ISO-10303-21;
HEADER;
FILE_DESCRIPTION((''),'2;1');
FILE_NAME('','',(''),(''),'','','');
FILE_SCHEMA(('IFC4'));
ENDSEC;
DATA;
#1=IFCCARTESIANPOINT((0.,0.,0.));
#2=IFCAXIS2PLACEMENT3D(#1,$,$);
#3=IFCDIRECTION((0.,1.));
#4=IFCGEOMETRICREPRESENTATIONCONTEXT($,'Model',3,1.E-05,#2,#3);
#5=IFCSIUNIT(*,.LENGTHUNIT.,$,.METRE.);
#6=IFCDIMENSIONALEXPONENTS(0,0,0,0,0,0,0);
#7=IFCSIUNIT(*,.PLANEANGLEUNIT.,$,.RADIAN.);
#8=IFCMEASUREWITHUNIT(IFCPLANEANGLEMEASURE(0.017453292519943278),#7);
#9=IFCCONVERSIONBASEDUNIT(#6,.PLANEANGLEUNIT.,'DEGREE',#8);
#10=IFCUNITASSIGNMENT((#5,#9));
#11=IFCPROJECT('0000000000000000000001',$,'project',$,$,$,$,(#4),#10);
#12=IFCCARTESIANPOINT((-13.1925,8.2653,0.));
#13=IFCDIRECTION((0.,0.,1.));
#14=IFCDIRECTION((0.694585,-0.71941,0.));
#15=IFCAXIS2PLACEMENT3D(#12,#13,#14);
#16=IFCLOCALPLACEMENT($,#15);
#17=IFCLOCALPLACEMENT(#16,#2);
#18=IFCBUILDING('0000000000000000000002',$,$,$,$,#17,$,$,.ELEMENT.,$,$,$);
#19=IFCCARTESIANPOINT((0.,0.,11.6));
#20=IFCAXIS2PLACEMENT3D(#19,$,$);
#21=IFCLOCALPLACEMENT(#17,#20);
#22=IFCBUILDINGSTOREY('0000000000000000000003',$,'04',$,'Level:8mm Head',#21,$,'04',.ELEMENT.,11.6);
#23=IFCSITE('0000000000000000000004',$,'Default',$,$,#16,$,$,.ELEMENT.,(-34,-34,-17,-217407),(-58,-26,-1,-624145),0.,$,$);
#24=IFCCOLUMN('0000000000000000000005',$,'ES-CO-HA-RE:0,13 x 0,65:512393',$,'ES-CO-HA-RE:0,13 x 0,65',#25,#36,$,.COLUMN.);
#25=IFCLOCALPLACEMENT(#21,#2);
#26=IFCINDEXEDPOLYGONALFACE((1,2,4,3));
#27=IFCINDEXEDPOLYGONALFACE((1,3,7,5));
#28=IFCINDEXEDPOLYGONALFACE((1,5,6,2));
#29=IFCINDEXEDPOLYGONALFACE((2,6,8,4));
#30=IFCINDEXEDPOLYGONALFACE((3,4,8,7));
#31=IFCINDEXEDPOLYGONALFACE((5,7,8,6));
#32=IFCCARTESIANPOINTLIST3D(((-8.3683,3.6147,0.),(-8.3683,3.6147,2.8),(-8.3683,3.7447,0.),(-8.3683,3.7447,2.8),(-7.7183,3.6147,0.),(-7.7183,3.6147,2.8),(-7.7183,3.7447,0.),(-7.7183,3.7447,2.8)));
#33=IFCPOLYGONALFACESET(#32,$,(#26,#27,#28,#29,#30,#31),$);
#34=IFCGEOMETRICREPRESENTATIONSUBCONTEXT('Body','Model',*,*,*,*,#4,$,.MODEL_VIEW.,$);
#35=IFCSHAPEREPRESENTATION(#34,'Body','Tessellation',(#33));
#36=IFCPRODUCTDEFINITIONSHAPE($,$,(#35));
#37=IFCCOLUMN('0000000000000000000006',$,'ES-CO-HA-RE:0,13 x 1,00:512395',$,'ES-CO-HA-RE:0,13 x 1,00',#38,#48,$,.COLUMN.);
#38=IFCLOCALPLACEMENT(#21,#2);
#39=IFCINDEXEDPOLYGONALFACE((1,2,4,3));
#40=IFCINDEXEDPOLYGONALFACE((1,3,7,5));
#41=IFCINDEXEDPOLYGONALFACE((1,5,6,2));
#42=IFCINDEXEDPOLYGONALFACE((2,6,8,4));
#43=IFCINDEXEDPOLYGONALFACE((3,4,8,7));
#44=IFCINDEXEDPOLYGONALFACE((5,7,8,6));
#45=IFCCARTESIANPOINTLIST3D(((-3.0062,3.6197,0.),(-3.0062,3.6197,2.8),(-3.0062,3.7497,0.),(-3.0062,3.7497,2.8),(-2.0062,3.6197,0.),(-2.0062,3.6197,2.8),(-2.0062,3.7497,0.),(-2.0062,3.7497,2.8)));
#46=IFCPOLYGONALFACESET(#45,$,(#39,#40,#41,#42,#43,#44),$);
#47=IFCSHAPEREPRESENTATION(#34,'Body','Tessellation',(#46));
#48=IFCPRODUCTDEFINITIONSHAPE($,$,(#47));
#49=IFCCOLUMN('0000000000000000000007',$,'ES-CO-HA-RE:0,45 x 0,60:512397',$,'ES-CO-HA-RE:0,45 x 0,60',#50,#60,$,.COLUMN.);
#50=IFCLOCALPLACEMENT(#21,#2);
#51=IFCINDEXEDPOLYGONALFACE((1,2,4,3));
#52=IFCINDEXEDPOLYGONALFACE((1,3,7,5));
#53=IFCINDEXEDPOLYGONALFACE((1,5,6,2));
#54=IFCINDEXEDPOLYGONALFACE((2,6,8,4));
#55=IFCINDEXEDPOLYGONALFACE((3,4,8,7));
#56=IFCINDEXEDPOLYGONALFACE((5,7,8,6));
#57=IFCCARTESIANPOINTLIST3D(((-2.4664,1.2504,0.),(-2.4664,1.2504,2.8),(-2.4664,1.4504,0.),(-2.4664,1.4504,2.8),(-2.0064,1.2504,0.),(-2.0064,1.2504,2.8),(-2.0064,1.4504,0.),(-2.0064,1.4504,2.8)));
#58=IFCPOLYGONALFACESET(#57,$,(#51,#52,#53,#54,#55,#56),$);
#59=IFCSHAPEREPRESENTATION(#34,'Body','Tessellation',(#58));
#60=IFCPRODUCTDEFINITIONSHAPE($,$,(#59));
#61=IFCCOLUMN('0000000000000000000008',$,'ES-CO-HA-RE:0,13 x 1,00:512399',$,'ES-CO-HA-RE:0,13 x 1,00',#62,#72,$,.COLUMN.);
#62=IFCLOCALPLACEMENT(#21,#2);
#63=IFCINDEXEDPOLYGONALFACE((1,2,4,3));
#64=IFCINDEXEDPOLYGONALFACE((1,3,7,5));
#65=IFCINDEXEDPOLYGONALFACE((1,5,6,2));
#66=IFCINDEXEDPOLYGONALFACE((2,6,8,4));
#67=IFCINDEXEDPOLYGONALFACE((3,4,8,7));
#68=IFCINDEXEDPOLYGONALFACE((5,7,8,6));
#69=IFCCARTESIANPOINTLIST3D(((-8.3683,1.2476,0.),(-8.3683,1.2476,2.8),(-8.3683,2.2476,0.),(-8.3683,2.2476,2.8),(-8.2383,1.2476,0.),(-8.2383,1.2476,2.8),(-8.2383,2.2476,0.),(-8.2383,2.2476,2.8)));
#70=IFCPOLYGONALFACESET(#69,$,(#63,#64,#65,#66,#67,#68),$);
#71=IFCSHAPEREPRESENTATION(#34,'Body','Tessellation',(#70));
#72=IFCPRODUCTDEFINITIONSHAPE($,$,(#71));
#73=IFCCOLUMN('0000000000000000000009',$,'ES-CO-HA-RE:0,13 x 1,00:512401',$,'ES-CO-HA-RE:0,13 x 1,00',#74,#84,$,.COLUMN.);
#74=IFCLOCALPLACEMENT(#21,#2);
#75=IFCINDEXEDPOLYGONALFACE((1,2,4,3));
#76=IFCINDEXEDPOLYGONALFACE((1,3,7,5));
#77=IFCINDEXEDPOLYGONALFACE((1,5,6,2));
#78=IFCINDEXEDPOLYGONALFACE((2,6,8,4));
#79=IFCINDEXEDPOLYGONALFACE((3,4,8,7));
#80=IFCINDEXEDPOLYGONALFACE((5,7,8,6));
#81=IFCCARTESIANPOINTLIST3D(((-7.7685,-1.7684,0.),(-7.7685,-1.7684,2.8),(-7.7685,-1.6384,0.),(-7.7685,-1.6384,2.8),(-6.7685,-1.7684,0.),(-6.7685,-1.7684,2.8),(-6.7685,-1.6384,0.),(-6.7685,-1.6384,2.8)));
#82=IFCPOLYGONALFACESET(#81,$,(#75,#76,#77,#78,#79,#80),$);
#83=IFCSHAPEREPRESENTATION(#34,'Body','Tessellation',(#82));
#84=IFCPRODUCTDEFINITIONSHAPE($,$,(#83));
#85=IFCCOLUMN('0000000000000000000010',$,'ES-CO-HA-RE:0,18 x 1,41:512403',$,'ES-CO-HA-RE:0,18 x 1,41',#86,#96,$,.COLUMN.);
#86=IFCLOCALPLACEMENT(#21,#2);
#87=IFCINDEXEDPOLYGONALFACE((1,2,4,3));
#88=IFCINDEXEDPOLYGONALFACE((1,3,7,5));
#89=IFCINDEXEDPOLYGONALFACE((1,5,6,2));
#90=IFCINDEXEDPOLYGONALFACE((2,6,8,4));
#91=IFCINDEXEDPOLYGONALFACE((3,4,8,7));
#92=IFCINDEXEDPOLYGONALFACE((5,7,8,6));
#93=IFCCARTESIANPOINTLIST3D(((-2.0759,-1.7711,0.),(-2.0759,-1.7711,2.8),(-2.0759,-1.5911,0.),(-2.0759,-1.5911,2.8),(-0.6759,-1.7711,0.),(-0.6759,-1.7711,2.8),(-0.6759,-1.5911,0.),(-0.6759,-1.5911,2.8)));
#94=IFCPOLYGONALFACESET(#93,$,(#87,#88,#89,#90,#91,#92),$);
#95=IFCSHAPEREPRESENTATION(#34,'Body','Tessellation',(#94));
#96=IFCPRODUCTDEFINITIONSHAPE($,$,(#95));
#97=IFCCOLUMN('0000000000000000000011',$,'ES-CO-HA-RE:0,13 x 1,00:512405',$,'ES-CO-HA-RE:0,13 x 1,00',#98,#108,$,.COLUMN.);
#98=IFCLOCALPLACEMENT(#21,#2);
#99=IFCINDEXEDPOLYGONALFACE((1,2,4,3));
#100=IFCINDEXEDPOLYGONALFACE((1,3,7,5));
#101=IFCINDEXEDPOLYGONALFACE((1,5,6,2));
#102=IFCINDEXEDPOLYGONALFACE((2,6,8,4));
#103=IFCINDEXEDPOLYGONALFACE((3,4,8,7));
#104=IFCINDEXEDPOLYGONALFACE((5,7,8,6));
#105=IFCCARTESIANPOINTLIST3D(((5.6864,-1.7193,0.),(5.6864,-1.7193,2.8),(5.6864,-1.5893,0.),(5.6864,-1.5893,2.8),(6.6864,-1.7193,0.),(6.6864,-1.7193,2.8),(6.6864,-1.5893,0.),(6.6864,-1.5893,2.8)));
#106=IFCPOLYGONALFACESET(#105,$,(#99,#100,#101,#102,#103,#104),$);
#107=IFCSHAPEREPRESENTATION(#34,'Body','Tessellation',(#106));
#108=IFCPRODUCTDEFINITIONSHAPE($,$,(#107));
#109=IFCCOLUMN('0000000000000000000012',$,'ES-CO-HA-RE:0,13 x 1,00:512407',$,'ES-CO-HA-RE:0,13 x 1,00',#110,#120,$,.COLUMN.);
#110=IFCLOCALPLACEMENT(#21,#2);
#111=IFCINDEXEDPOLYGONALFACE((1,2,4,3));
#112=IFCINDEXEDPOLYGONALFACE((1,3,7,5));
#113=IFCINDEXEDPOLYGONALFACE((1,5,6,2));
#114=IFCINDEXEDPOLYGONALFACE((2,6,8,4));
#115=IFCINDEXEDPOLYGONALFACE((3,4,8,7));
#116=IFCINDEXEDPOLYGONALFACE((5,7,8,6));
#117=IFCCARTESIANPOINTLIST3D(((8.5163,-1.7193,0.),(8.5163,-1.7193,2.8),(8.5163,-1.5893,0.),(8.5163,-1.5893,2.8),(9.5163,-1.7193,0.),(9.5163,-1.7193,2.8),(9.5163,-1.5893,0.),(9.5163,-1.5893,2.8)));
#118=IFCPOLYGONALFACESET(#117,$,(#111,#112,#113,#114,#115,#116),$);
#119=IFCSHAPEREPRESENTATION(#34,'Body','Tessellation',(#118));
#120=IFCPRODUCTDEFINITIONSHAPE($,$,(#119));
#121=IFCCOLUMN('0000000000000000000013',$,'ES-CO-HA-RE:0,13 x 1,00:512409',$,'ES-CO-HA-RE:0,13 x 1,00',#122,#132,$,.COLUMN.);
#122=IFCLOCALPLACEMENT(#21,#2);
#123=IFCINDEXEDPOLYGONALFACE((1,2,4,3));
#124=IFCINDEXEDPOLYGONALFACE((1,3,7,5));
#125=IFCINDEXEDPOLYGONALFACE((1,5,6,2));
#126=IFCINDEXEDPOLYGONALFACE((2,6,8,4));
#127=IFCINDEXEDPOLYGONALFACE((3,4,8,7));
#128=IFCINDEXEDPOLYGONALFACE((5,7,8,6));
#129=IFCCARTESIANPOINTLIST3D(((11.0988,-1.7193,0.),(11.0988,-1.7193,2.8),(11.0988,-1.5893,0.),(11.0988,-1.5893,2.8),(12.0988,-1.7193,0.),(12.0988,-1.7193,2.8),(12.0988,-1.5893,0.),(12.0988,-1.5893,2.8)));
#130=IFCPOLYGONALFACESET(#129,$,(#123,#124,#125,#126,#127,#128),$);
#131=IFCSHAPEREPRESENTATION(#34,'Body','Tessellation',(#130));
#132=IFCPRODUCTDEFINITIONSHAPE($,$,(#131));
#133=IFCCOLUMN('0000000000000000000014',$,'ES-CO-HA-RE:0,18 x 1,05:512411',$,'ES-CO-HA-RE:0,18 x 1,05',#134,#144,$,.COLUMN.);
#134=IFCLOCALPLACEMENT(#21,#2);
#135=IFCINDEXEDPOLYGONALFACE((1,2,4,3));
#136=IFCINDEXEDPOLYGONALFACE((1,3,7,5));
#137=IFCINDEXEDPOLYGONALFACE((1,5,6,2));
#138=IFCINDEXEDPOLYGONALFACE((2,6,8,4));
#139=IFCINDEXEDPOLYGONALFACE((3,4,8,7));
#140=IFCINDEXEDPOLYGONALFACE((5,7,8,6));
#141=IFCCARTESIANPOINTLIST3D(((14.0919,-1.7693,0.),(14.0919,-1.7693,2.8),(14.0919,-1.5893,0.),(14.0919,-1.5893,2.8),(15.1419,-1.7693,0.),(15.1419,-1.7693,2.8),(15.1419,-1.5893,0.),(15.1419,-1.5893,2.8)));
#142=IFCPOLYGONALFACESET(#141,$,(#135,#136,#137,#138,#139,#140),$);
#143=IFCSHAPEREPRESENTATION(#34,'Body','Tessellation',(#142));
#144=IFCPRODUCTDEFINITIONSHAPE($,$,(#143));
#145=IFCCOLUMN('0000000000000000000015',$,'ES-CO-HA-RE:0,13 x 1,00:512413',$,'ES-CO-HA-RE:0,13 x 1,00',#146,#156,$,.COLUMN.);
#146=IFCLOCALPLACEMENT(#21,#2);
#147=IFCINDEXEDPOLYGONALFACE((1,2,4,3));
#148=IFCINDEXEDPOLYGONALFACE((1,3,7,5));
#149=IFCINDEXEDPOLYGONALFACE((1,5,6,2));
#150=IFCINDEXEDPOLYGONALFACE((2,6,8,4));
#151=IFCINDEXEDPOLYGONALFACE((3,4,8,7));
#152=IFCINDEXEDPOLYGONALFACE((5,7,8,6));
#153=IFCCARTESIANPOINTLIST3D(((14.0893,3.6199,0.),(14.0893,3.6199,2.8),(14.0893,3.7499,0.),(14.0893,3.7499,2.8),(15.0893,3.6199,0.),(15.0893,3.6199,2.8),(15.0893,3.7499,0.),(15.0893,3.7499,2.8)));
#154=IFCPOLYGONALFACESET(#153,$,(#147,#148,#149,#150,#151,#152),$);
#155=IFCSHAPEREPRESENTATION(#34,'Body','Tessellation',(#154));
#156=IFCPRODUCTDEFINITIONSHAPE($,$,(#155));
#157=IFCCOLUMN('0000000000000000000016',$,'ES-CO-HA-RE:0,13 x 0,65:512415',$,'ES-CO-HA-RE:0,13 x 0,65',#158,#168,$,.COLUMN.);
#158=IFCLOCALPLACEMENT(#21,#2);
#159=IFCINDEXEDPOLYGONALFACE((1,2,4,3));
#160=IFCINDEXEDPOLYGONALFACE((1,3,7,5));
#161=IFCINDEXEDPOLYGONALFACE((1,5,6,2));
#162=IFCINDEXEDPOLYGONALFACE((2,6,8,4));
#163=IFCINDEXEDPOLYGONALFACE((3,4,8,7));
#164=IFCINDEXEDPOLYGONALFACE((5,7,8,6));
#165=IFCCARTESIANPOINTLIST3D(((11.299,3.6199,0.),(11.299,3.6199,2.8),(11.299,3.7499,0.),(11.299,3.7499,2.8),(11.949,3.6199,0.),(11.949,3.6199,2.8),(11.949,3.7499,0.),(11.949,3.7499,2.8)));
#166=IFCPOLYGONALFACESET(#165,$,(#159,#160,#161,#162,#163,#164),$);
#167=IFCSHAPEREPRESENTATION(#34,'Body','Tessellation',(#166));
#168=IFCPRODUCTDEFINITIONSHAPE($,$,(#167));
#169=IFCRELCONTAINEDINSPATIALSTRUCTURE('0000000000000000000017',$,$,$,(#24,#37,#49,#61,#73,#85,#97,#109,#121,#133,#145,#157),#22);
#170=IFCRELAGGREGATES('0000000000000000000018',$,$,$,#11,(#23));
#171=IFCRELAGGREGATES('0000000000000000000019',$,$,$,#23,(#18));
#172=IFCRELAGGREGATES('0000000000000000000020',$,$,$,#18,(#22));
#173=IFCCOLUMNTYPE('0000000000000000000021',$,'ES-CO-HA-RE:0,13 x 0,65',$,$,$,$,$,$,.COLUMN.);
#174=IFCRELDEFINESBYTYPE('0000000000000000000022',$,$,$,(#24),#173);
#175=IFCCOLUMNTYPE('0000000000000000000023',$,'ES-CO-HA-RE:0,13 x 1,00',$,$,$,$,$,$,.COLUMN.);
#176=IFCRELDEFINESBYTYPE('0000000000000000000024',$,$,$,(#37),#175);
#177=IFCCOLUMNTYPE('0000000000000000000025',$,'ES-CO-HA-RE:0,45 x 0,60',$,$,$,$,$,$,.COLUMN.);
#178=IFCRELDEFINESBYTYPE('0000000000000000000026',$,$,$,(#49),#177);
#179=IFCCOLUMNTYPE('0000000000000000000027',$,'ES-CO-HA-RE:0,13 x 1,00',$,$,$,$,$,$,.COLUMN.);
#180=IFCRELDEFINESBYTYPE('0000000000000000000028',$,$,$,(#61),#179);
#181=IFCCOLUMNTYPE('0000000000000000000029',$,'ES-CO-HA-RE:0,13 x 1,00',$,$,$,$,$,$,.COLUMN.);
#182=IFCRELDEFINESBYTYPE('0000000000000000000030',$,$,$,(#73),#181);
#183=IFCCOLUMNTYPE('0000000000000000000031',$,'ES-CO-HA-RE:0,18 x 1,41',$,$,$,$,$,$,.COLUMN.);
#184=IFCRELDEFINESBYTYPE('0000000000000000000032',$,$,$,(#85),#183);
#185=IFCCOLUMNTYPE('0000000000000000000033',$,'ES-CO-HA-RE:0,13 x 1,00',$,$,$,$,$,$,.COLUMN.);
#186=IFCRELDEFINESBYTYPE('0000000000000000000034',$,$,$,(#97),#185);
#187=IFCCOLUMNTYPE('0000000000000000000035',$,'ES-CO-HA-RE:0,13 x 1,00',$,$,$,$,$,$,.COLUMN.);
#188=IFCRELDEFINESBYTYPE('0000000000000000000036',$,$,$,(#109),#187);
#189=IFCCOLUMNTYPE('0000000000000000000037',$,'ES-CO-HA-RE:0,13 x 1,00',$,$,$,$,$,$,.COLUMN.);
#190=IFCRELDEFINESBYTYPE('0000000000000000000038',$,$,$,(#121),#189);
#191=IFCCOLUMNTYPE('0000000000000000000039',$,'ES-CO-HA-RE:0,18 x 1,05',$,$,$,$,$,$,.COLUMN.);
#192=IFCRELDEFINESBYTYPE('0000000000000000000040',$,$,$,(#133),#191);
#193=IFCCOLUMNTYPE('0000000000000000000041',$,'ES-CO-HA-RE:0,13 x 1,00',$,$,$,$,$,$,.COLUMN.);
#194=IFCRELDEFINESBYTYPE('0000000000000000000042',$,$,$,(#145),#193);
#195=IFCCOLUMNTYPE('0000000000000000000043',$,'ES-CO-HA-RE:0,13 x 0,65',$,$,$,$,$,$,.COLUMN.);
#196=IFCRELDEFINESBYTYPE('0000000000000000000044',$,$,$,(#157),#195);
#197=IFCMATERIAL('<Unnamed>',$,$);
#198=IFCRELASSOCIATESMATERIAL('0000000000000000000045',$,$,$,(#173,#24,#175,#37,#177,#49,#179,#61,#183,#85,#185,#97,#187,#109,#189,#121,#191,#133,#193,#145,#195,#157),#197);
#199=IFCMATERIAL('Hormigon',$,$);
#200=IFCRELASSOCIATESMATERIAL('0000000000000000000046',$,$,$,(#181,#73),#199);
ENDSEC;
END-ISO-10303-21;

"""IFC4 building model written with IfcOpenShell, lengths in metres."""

from ifc_helpers import new_model, entity, si_unit, converted_unit, direction, frame, origin, place, context, subcontext, project, spatial, indexed_curve, outline, extrude, source, transform, mapped, material, type_object, type_shapes, element, save


model = new_model("IFC4")

# Units and contexts
model_context = context("Model", 3, precision=1e-05, world=origin(), true_north=direction((0.0, 1.0)))
body_context = subcontext(model_context, "Body", "Model", "MODEL_VIEW")
ifc_project = project(units=[si_unit("LENGTHUNIT", "METRE"), converted_unit("PLANEANGLEUNIT", "DEGREE", entity("IfcPlaneAngleMeasure", 0.017453292519943278), si_unit("PLANEANGLEUNIT", "RADIAN"), dimensions=[0, 0, 0, 0, 0, 0, 0])], contexts=[model_context])

# Site, building, storey
site_placement = place(None, frame((-13.1925, 8.2653, 0.0), z_axis=(0.0, 0.0, 1.0), x_axis=(0.694585, -0.71941, 0.0)))
site = spatial("IfcSite", under=ifc_project, at=site_placement, Name="Default", CompositionType="ELEMENT", RefLatitude=(-34, -34, -17, -217407), RefLongitude=(-58, -26, -1, -624145), RefElevation=0.0)
building_placement = place(site_placement, origin())
building = spatial("IfcBuilding", under=site, at=building_placement, CompositionType="ELEMENT")
storey_placement = place(building_placement, frame((0.0, 0.0, 11.6)))
storey = spatial("IfcBuildingStorey", under=building, at=storey_placement, Name="04", ObjectType="Level:8mm Head", LongName="04", CompositionType="ELEMENT", Elevation=11.6)

# Columns
ifc_material_1 = material(Name="<Unnamed>")
column_type_1 = type_object("IfcColumnType", Name="ES-CO-HA-RE:0,13 x 0,65", PredefinedType="COLUMN", material=ifc_material_1)
shared_shape_1 = source(origin(), body_context, "Body", "SweptSolid", [
    extrude(outline(indexed_curve([(-0.325, -0.065), (0.325, -0.065), (0.325, 0.065), (-0.325, 0.065), (-0.325, -0.065)], self_intersect=False)), frame((-8.0433, 3.6797, 11.6), z_axis=(0.0, 0.0, 1.0), x_axis=(-1.0, 0.0, 0.0)), (0.0, 0.0, 1.0), 2.8),
])
type_shapes(column_type_1, [shared_shape_1])
column_1_placement = place(storey_placement, frame((0.0, 0.0, -11.6)))
element("IfcColumn", 1, at=column_1_placement, inside=storey, type_object=column_type_1, material=ifc_material_1, Name="ES-CO-HA-RE:0,13 x 0,65:512393", ObjectType="ES-CO-HA-RE:0,13 x 0,65", PredefinedType="COLUMN", context=body_context, shape_type="MappedRepresentation", body=[
    mapped(shared_shape_1, transform((0.0, 0.0, 0.0), scale=1.0)),
])
column_type_2 = type_object("IfcColumnType", Name="ES-CO-HA-RE:0,13 x 1,00", PredefinedType="COLUMN", material=ifc_material_1)
shared_shape_2 = source(origin(), body_context, "Body", "SweptSolid", [
    extrude(outline(indexed_curve([(-0.5, -0.065), (0.5, -0.065), (0.5, 0.065), (-0.5, 0.065), (-0.5, -0.065)], self_intersect=False)), frame((-2.5062, 3.6847, 11.6), z_axis=(0.0, 0.0, 1.0), x_axis=(-1.0, 0.0, 0.0)), (0.0, 0.0, 1.0), 2.8),
])
type_shapes(column_type_2, [shared_shape_2])
column_2_placement = place(storey_placement, frame((0.0, 0.0, -11.6)))
element("IfcColumn", 2, at=column_2_placement, inside=storey, type_object=column_type_2, material=ifc_material_1, Name="ES-CO-HA-RE:0,13 x 1,00:512395", ObjectType="ES-CO-HA-RE:0,13 x 1,00", PredefinedType="COLUMN", context=body_context, shape_type="MappedRepresentation", body=[
    mapped(shared_shape_2, transform((0.0, 0.0, 0.0), scale=1.0)),
])
column_type_3 = type_object("IfcColumnType", Name="ES-CO-HA-RE:0,45 x 0,60", PredefinedType="COLUMN", material=ifc_material_1)
shared_shape_3 = source(origin(), body_context, "Body", "SweptSolid", [
    extrude(outline(indexed_curve([(-0.23, -0.1), (0.23, -0.1), (0.23, 0.1), (-0.23, 0.1), (-0.23, -0.1)], self_intersect=False)), frame((-2.2364, 1.3504, 11.6), z_axis=(0.0, 0.0, 1.0), x_axis=(-1.0, 0.0, 0.0)), (0.0, 0.0, 1.0), 2.8),
])
type_shapes(column_type_3, [shared_shape_3])
column_3_placement = place(storey_placement, frame((0.0, 0.0, -11.6)))
element("IfcColumn", 3, at=column_3_placement, inside=storey, type_object=column_type_3, material=ifc_material_1, Name="ES-CO-HA-RE:0,45 x 0,60:512397", ObjectType="ES-CO-HA-RE:0,45 x 0,60", PredefinedType="COLUMN", context=body_context, shape_type="MappedRepresentation", body=[
    mapped(shared_shape_3, transform((0.0, 0.0, 0.0), scale=1.0)),
])
column_type_4 = type_object("IfcColumnType", Name="ES-CO-HA-RE:0,13 x 1,00", PredefinedType="COLUMN", material=ifc_material_1)
shared_shape_4 = source(origin(), body_context, "Body", "SweptSolid", [
    extrude(outline(indexed_curve([(-0.5, -0.065), (0.5, -0.065), (0.5, 0.065), (-0.5, 0.065), (-0.5, -0.065)], self_intersect=False)), frame((-8.3033, 1.7476, 11.6), z_axis=(0.0, 0.0, 1.0), x_axis=(0.0, -1.0, 0.0)), (0.0, 0.0, 1.0), 2.8),
])
type_shapes(column_type_4, [shared_shape_4])
column_4_placement = place(storey_placement, frame((0.0, 0.0, -11.6)))
element("IfcColumn", 4, at=column_4_placement, inside=storey, type_object=column_type_4, material=ifc_material_1, Name="ES-CO-HA-RE:0,13 x 1,00:512399", ObjectType="ES-CO-HA-RE:0,13 x 1,00", PredefinedType="COLUMN", context=body_context, shape_type="MappedRepresentation", body=[
    mapped(shared_shape_4, transform((0.0, 0.0, 0.0), scale=1.0)),
])
ifc_material_2 = material(Name="Hormigon")
column_type_5 = type_object("IfcColumnType", Name="ES-CO-HA-RE:0,13 x 1,00", PredefinedType="COLUMN", material=ifc_material_2)
shared_shape_5 = source(origin(), body_context, "Body", "SweptSolid", [
    extrude(outline(indexed_curve([(-0.5, -0.065), (0.5, -0.065), (0.5, 0.065), (-0.5, 0.065), (-0.5, -0.065)], self_intersect=False)), frame((-7.2685, -1.7034, 11.6), z_axis=(0.0, 0.0, 1.0), x_axis=(-1.0, 0.0, 0.0)), (0.0, 0.0, 1.0), 2.8),
])
type_shapes(column_type_5, [shared_shape_5])
column_5_placement = place(storey_placement, frame((0.0, 0.0, -11.6)))
element("IfcColumn", 5, at=column_5_placement, inside=storey, type_object=column_type_5, material=ifc_material_2, Name="ES-CO-HA-RE:0,13 x 1,00:512401", ObjectType="ES-CO-HA-RE:0,13 x 1,00", PredefinedType="COLUMN", context=body_context, shape_type="MappedRepresentation", body=[
    mapped(shared_shape_5, transform((0.0, 0.0, 0.0), scale=1.0)),
])
column_type_6 = type_object("IfcColumnType", Name="ES-CO-HA-RE:0,18 x 1,41", PredefinedType="COLUMN", material=ifc_material_1)
shared_shape_6 = source(origin(), body_context, "Body", "SweptSolid", [
    extrude(outline(indexed_curve([(-0.7, -0.09), (0.7, -0.09), (0.7, 0.09), (-0.7, 0.09), (-0.7, -0.09)], self_intersect=False)), frame((-1.3759, -1.6811, 11.6), z_axis=(0.0, 0.0, 1.0), x_axis=(-1.0, 0.0, 0.0)), (0.0, 0.0, 1.0), 2.8),
])
type_shapes(column_type_6, [shared_shape_6])
column_6_placement = place(storey_placement, frame((0.0, 0.0, -11.6)))
element("IfcColumn", 6, at=column_6_placement, inside=storey, type_object=column_type_6, material=ifc_material_1, Name="ES-CO-HA-RE:0,18 x 1,41:512403", ObjectType="ES-CO-HA-RE:0,18 x 1,41", PredefinedType="COLUMN", context=body_context, shape_type="MappedRepresentation", body=[
    mapped(shared_shape_6, transform((0.0, 0.0, 0.0), scale=1.0)),
])
column_type_7 = type_object("IfcColumnType", Name="ES-CO-HA-RE:0,13 x 1,00", PredefinedType="COLUMN", material=ifc_material_1)
shared_shape_7 = source(origin(), body_context, "Body", "SweptSolid", [
    extrude(outline(indexed_curve([(-0.5, -0.065), (0.5, -0.065), (0.5, 0.065), (-0.5, 0.065), (-0.5, -0.065)], self_intersect=False)), frame((6.1864, -1.6543, 11.6), z_axis=(0.0, 0.0, 1.0), x_axis=(-1.0, 0.0, 0.0)), (0.0, 0.0, 1.0), 2.8),
])
type_shapes(column_type_7, [shared_shape_7])
column_7_placement = place(storey_placement, frame((0.0, 0.0, -11.6)))
element("IfcColumn", 7, at=column_7_placement, inside=storey, type_object=column_type_7, material=ifc_material_1, Name="ES-CO-HA-RE:0,13 x 1,00:512405", ObjectType="ES-CO-HA-RE:0,13 x 1,00", PredefinedType="COLUMN", context=body_context, shape_type="MappedRepresentation", body=[
    mapped(shared_shape_7, transform((0.0, 0.0, 0.0), scale=1.0)),
])
column_type_8 = type_object("IfcColumnType", Name="ES-CO-HA-RE:0,13 x 1,00", PredefinedType="COLUMN", material=ifc_material_1)
shared_shape_8 = source(origin(), body_context, "Body", "SweptSolid", [
    extrude(outline(indexed_curve([(-0.5, -0.065), (0.5, -0.065), (0.5, 0.065), (-0.5, 0.065), (-0.5, -0.065)], self_intersect=False)), frame((9.0163, -1.6543, 11.6), z_axis=(0.0, 0.0, 1.0), x_axis=(-1.0, 0.0, 0.0)), (0.0, 0.0, 1.0), 2.8),
])
type_shapes(column_type_8, [shared_shape_8])
column_8_placement = place(storey_placement, frame((0.0, 0.0, -11.6)))
element("IfcColumn", 8, at=column_8_placement, inside=storey, type_object=column_type_8, material=ifc_material_1, Name="ES-CO-HA-RE:0,13 x 1,00:512407", ObjectType="ES-CO-HA-RE:0,13 x 1,00", PredefinedType="COLUMN", context=body_context, shape_type="MappedRepresentation", body=[
    mapped(shared_shape_8, transform((0.0, 0.0, 0.0), scale=1.0)),
])
column_type_9 = type_object("IfcColumnType", Name="ES-CO-HA-RE:0,13 x 1,00", PredefinedType="COLUMN", material=ifc_material_1)
shared_shape_9 = source(origin(), body_context, "Body", "SweptSolid", [
    extrude(outline(indexed_curve([(-0.5, -0.065), (0.5, -0.065), (0.5, 0.065), (-0.5, 0.065), (-0.5, -0.065)], self_intersect=False)), frame((11.5988, -1.6543, 11.6), z_axis=(0.0, 0.0, 1.0), x_axis=(-1.0, 0.0, 0.0)), (0.0, 0.0, 1.0), 2.8),
])
type_shapes(column_type_9, [shared_shape_9])
column_9_placement = place(storey_placement, frame((0.0, 0.0, -11.6)))
element("IfcColumn", 9, at=column_9_placement, inside=storey, type_object=column_type_9, material=ifc_material_1, Name="ES-CO-HA-RE:0,13 x 1,00:512409", ObjectType="ES-CO-HA-RE:0,13 x 1,00", PredefinedType="COLUMN", context=body_context, shape_type="MappedRepresentation", body=[
    mapped(shared_shape_9, transform((0.0, 0.0, 0.0), scale=1.0)),
])
column_type_10 = type_object("IfcColumnType", Name="ES-CO-HA-RE:0,18 x 1,05", PredefinedType="COLUMN", material=ifc_material_1)
shared_shape_10 = source(origin(), body_context, "Body", "SweptSolid", [
    extrude(outline(indexed_curve([(-0.525, -0.09), (0.525, -0.09), (0.525, 0.09), (-0.525, 0.09), (-0.525, -0.09)], self_intersect=False)), frame((14.6169, -1.6793, 11.6), z_axis=(0.0, 0.0, 1.0), x_axis=(-1.0, 0.0, 0.0)), (0.0, 0.0, 1.0), 2.8),
])
type_shapes(column_type_10, [shared_shape_10])
column_10_placement = place(storey_placement, frame((0.0, 0.0, -11.6)))
element("IfcColumn", 10, at=column_10_placement, inside=storey, type_object=column_type_10, material=ifc_material_1, Name="ES-CO-HA-RE:0,18 x 1,05:512411", ObjectType="ES-CO-HA-RE:0,18 x 1,05", PredefinedType="COLUMN", context=body_context, shape_type="MappedRepresentation", body=[
    mapped(shared_shape_10, transform((0.0, 0.0, 0.0), scale=1.0)),
])
column_type_11 = type_object("IfcColumnType", Name="ES-CO-HA-RE:0,13 x 1,00", PredefinedType="COLUMN", material=ifc_material_1)
shared_shape_11 = source(origin(), body_context, "Body", "SweptSolid", [
    extrude(outline(indexed_curve([(-0.5, -0.065), (0.5, -0.065), (0.5, 0.065), (-0.5, 0.065), (-0.5, -0.065)], self_intersect=False)), frame((14.5893, 3.6849, 11.6), z_axis=(0.0, 0.0, 1.0), x_axis=(-1.0, 0.0, 0.0)), (0.0, 0.0, 1.0), 2.8),
])
type_shapes(column_type_11, [shared_shape_11])
column_11_placement = place(storey_placement, frame((0.0, 0.0, -11.6)))
element("IfcColumn", 11, at=column_11_placement, inside=storey, type_object=column_type_11, material=ifc_material_1, Name="ES-CO-HA-RE:0,13 x 1,00:512413", ObjectType="ES-CO-HA-RE:0,13 x 1,00", PredefinedType="COLUMN", context=body_context, shape_type="MappedRepresentation", body=[
    mapped(shared_shape_11, transform((0.0, 0.0, 0.0), scale=1.0)),
])
column_type_12 = type_object("IfcColumnType", Name="ES-CO-HA-RE:0,13 x 0,65", PredefinedType="COLUMN", material=ifc_material_1)
shared_shape_12 = source(origin(), body_context, "Body", "SweptSolid", [
    extrude(outline(indexed_curve([(-0.325, -0.065), (0.325, -0.065), (0.325, 0.065), (-0.325, 0.065), (-0.325, -0.065)], self_intersect=False)), frame((11.624, 3.6849, 11.6), z_axis=(0.0, 0.0, 1.0), x_axis=(-1.0, 0.0, 0.0)), (0.0, 0.0, 1.0), 2.8),
])
type_shapes(column_type_12, [shared_shape_12])
column_12_placement = place(storey_placement, frame((0.0, 0.0, -11.6)))
element("IfcColumn", 12, at=column_12_placement, inside=storey, type_object=column_type_12, material=ifc_material_1, Name="ES-CO-HA-RE:0,13 x 0,65:512415", ObjectType="ES-CO-HA-RE:0,13 x 0,65", PredefinedType="COLUMN", context=body_context, shape_type="MappedRepresentation", body=[
    mapped(shared_shape_12, transform((0.0, 0.0, 0.0), scale=1.0)),
])

save(model, "model.ifc")
